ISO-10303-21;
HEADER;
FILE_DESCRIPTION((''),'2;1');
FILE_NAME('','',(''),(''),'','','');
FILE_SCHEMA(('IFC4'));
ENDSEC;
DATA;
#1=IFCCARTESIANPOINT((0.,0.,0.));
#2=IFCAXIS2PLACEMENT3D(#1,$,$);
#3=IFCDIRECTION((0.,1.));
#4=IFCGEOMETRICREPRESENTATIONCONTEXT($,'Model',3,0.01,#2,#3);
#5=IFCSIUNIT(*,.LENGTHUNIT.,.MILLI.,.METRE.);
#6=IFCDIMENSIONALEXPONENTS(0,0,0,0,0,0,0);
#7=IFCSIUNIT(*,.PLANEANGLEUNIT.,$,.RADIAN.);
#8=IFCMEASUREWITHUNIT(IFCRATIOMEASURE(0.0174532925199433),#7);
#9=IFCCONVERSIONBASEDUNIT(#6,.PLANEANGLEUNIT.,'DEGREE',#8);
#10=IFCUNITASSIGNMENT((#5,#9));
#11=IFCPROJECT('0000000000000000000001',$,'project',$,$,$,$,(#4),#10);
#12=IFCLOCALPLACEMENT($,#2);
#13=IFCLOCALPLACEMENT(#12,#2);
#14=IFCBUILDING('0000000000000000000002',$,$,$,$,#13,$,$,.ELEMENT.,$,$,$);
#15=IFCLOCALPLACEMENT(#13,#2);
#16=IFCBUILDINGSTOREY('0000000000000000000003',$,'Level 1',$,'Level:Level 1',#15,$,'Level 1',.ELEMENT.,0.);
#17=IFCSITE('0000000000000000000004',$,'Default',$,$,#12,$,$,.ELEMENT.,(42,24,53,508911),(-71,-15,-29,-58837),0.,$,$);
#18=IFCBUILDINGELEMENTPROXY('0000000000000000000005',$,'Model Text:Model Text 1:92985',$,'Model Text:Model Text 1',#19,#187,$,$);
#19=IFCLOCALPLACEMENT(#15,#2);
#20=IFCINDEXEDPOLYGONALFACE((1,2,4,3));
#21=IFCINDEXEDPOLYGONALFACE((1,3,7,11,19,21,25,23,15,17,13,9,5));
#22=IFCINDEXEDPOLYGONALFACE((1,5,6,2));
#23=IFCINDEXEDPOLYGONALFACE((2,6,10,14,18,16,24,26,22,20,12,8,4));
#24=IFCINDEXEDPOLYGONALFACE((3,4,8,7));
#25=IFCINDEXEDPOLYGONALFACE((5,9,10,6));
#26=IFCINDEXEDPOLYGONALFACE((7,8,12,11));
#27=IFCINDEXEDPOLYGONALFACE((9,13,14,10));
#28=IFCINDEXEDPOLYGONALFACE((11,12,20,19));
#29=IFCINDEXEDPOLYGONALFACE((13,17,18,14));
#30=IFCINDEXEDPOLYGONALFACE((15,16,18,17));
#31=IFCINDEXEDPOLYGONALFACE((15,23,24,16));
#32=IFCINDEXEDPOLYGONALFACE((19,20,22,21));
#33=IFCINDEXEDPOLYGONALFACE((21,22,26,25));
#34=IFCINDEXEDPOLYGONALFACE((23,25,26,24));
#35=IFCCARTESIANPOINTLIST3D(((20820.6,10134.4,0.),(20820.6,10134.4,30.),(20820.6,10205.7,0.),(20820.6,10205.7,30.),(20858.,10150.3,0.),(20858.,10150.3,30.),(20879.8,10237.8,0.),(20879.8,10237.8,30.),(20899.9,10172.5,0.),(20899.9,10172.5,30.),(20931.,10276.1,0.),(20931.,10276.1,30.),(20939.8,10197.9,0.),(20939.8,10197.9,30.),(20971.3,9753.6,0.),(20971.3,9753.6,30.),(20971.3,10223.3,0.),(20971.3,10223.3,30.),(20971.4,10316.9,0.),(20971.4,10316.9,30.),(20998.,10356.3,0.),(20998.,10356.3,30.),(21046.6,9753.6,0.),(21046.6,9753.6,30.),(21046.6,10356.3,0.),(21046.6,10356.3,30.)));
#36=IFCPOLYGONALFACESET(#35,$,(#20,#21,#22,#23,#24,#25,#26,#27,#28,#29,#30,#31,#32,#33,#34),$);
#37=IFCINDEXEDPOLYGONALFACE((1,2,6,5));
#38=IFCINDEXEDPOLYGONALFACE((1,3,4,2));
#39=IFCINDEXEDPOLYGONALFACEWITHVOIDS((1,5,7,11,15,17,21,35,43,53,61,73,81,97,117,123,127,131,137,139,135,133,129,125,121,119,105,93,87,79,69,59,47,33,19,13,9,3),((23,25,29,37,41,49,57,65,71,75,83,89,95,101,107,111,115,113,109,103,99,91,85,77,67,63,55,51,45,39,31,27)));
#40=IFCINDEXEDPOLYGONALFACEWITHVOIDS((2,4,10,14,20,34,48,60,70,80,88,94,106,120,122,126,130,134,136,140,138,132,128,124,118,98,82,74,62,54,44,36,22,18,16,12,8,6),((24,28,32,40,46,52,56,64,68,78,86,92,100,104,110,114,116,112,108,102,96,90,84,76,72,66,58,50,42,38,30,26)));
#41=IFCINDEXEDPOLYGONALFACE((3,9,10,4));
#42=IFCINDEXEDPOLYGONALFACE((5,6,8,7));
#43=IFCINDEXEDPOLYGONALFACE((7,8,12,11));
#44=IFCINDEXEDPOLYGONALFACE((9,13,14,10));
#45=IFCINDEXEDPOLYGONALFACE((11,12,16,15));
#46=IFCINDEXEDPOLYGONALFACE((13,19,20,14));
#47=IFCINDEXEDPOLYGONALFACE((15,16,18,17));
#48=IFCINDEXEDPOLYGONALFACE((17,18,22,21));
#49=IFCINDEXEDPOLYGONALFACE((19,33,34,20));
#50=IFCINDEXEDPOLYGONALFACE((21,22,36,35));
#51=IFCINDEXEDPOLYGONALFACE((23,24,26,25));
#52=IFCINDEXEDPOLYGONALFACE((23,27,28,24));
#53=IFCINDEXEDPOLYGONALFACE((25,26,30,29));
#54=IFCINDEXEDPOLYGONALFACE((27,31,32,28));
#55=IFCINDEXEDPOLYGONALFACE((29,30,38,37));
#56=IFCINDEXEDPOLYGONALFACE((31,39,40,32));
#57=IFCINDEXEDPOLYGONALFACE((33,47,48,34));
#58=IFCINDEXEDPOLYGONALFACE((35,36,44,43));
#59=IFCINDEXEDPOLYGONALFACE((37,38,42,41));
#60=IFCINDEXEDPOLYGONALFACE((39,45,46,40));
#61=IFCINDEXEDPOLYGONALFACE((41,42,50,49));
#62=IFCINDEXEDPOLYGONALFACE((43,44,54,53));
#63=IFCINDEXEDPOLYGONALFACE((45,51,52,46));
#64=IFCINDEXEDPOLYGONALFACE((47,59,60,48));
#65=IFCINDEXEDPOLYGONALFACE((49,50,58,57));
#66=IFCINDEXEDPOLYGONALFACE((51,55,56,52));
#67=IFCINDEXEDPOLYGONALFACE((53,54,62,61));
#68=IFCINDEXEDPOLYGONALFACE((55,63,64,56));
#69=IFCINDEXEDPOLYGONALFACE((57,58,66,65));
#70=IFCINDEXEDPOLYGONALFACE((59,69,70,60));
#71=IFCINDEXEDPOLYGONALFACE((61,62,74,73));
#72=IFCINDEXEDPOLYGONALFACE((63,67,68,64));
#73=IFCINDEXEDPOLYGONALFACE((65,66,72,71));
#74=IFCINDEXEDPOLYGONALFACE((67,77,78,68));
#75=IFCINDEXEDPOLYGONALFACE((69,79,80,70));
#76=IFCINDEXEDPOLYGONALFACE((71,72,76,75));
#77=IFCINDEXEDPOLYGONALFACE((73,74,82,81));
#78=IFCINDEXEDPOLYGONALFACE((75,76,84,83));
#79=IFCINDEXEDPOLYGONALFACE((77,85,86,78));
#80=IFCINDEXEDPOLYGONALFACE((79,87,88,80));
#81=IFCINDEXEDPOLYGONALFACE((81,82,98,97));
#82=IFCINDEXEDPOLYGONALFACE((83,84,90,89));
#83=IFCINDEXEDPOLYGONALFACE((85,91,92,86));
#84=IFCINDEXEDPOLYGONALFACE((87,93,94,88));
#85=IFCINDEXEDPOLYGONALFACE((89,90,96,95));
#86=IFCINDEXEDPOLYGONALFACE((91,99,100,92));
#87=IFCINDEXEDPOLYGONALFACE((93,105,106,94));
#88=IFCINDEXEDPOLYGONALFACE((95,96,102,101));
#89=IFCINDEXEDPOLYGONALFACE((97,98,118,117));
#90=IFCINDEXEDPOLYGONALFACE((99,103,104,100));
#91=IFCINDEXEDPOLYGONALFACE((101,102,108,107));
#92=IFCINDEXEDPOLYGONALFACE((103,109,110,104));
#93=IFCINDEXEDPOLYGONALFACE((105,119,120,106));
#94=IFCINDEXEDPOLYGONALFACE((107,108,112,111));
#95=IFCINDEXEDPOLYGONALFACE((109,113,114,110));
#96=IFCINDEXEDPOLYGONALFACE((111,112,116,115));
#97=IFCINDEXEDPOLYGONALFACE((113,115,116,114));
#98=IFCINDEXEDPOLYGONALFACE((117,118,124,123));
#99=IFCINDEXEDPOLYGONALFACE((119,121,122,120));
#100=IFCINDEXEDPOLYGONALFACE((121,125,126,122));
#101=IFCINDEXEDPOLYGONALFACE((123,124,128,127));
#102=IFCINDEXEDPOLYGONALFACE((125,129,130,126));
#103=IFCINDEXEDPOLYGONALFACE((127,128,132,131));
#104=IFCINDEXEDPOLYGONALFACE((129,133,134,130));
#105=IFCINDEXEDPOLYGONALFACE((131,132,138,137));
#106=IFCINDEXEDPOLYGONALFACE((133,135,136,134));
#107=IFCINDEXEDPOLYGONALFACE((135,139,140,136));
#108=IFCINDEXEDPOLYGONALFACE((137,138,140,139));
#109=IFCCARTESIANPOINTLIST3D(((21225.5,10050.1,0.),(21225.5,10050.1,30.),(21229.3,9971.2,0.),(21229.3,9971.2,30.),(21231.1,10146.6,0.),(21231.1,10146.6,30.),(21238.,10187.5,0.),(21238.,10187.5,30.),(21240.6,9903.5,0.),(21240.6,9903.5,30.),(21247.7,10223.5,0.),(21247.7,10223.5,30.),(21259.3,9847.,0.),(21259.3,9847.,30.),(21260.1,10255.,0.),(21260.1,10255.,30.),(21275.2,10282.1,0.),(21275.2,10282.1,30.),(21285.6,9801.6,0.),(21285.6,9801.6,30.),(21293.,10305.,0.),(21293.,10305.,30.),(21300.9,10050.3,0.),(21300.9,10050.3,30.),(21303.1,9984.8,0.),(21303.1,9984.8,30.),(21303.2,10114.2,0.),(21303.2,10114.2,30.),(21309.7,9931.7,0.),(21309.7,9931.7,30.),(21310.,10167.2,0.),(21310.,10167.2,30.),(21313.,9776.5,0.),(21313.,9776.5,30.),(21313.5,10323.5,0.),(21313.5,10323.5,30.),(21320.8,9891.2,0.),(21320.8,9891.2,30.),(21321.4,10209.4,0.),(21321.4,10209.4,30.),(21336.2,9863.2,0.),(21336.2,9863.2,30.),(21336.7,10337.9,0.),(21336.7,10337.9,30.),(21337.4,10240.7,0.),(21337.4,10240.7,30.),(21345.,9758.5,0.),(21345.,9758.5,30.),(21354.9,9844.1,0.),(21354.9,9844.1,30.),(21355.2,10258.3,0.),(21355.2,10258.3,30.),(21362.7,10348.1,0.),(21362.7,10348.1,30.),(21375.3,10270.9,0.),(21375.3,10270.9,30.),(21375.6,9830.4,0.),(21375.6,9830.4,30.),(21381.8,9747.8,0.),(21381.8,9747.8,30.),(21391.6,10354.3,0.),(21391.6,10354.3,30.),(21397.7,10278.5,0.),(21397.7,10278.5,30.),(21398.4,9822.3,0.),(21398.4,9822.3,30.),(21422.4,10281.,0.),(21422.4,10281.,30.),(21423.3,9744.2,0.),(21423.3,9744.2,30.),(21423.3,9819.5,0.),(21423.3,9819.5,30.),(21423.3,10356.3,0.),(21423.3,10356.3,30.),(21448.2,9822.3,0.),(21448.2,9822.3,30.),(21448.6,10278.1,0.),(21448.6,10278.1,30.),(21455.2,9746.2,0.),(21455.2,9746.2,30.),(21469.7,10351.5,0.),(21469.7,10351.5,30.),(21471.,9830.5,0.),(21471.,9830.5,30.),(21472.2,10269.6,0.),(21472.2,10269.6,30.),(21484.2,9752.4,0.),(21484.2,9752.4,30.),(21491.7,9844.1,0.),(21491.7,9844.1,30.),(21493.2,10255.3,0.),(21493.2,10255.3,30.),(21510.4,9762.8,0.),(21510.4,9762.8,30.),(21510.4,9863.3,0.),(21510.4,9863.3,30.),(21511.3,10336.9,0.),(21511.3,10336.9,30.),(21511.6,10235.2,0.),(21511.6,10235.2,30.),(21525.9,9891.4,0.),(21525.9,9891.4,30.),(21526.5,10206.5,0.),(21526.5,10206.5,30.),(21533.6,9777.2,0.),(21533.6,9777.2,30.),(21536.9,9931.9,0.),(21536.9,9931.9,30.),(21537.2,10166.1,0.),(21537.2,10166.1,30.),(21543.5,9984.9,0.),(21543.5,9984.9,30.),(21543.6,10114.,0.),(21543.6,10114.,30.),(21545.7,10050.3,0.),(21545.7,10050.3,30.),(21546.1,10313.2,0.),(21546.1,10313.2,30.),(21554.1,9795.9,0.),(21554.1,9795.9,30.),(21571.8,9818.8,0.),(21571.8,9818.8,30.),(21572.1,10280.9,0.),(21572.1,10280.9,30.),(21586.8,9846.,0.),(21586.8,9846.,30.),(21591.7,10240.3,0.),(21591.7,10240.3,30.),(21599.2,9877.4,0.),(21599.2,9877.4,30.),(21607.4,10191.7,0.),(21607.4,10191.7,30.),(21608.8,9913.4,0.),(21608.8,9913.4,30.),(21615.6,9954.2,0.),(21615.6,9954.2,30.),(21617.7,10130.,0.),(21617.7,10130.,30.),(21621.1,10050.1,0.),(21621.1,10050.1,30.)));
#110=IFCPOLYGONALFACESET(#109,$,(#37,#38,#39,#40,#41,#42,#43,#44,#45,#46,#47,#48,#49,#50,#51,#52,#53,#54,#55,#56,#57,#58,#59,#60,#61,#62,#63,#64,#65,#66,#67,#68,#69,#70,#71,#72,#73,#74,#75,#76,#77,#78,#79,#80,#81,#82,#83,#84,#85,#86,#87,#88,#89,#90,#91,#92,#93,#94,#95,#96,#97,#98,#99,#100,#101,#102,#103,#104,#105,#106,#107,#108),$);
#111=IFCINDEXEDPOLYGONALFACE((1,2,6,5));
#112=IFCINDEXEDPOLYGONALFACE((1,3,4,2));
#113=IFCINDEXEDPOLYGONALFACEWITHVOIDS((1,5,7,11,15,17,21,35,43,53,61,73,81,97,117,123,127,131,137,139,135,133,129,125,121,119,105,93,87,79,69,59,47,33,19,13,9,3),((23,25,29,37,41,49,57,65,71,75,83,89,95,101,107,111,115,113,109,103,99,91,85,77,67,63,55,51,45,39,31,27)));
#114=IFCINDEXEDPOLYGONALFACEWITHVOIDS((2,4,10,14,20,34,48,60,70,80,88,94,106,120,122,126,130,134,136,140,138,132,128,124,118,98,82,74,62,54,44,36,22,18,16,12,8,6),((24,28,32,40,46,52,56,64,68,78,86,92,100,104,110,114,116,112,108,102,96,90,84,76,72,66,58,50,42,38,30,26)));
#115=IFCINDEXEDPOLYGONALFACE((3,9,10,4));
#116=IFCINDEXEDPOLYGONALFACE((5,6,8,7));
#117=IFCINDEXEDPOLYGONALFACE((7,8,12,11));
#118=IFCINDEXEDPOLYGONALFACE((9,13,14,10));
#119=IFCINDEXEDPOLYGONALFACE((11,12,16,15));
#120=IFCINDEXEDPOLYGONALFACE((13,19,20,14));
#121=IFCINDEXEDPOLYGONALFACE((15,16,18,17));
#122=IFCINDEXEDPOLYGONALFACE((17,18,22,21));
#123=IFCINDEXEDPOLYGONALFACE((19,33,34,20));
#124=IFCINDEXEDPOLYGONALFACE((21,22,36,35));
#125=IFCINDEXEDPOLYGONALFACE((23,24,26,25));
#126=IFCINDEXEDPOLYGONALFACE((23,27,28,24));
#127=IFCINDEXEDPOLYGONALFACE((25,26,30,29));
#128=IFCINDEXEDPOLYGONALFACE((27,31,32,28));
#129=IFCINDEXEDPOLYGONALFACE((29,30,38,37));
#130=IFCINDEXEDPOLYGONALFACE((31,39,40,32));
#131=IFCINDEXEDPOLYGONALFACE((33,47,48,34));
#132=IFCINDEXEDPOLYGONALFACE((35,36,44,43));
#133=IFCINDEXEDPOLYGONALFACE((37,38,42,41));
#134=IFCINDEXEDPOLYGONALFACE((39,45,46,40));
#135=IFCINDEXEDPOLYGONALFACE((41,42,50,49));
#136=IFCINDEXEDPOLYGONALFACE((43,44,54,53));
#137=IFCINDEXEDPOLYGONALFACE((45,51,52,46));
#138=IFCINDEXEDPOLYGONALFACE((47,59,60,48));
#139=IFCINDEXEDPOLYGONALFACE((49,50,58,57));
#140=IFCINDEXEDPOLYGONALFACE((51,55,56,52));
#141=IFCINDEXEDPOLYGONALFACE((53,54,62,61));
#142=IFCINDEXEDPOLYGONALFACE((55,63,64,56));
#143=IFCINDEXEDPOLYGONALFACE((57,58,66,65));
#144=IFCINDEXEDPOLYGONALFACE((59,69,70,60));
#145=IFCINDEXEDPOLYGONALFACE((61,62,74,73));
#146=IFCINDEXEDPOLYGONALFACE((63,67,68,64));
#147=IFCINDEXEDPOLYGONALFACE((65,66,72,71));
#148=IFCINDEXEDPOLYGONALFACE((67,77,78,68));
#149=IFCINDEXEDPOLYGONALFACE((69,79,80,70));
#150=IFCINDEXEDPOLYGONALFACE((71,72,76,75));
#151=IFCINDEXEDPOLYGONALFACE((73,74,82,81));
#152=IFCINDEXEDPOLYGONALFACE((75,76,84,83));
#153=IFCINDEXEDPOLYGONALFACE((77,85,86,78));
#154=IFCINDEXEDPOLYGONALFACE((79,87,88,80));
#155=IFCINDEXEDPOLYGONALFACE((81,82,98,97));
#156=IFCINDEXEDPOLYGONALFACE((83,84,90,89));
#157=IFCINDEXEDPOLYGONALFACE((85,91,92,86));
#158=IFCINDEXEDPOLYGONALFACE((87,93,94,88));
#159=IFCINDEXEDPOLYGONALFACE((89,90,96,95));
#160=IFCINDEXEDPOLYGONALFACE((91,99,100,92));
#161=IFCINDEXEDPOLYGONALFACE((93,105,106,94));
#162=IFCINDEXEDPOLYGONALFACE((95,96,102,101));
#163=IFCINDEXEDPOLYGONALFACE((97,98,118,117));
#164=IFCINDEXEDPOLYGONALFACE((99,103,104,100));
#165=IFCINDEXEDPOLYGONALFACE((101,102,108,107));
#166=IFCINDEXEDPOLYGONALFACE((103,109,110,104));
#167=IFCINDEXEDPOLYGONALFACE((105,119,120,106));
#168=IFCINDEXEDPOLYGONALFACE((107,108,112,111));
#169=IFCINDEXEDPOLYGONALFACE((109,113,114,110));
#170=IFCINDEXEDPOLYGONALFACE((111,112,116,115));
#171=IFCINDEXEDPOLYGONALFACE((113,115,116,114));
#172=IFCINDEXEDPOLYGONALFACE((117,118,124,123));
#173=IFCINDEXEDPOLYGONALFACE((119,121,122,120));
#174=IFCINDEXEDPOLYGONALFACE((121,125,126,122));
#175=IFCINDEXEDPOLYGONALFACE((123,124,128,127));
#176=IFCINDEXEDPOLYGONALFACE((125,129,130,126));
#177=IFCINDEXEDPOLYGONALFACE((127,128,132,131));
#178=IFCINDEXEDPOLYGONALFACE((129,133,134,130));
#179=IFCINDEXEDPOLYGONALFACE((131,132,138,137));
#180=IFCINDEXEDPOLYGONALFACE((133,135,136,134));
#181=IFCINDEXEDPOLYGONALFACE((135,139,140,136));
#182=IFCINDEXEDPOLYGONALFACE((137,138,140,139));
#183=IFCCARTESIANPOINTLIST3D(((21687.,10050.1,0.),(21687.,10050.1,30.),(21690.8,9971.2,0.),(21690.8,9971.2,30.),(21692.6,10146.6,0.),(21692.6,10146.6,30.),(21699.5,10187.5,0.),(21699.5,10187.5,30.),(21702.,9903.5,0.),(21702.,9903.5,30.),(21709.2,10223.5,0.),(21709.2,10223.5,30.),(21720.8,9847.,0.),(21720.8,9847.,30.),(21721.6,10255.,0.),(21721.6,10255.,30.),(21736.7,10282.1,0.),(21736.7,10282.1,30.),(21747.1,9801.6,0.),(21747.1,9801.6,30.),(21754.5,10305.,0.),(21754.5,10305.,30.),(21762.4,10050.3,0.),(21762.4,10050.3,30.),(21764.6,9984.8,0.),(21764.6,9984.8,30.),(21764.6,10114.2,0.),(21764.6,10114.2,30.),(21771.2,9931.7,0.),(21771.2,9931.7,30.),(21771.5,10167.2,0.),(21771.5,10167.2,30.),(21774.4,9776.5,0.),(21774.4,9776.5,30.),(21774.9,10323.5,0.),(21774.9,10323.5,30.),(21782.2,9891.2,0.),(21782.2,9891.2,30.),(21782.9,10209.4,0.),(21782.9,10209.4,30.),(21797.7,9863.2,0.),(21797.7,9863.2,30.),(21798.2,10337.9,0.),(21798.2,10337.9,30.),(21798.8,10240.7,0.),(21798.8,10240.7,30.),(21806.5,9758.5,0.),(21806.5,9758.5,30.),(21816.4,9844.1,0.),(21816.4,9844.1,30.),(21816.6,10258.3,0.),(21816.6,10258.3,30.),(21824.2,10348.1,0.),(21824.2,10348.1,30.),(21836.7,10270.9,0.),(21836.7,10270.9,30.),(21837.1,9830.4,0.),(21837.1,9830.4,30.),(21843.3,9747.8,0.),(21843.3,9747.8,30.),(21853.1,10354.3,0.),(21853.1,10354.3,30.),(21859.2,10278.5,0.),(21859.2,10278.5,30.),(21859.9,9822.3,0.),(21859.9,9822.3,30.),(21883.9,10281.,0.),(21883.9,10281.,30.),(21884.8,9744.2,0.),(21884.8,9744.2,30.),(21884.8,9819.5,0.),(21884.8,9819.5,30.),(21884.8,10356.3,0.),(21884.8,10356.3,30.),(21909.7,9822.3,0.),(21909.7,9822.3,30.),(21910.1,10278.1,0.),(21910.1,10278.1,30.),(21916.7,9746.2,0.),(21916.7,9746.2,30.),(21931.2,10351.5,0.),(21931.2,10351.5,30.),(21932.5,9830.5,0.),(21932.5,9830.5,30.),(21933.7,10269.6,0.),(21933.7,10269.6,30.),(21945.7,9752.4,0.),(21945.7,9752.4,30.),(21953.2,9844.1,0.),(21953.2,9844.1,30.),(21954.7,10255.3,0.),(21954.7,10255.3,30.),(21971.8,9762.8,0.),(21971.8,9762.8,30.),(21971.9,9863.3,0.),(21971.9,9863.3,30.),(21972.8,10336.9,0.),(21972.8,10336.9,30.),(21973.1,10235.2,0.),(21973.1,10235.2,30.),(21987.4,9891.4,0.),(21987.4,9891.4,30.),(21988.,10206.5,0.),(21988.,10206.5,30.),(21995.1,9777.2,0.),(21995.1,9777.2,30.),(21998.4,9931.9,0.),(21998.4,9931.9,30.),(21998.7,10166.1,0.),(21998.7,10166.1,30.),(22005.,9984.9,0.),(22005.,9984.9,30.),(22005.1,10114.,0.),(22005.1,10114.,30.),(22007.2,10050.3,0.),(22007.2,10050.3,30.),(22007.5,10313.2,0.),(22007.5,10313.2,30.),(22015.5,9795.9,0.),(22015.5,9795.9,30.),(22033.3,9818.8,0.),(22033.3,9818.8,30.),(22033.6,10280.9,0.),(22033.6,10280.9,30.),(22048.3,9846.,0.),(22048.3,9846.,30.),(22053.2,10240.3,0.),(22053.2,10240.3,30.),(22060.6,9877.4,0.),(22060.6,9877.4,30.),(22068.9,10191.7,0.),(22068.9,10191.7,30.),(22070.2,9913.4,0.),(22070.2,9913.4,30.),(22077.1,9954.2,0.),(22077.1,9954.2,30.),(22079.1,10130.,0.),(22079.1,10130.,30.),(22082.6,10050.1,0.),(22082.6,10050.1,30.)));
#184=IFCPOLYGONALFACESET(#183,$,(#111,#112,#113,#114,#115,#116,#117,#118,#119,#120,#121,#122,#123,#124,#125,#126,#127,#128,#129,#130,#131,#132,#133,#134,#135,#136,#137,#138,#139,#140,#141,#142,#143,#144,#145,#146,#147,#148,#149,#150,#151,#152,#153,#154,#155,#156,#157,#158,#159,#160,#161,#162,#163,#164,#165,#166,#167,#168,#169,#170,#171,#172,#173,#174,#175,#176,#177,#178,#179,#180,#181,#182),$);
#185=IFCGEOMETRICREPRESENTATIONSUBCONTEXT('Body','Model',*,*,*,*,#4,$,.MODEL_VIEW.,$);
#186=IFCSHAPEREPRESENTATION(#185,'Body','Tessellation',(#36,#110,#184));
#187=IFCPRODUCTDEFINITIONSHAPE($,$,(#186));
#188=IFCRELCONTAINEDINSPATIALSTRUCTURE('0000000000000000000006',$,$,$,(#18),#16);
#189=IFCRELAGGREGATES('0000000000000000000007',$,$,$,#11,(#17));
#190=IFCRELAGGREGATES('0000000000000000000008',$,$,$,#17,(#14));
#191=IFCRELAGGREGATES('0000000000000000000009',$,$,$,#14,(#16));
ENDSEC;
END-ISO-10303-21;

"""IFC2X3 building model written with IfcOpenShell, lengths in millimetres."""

from ifc_helpers import new_model, entity, si_unit, converted_unit, direction, frame, origin, place, context, subcontext, project, spatial, polyline, outline, extrude, element, save


model = new_model("IFC2X3")

# Units and contexts
model_context = context("Model", 3, precision=0.01, world=origin(), true_north=direction((0.0, 1.0)))
body_context = subcontext(model_context, "Body", "Model", "MODEL_VIEW")
ifc_project = project(units=[si_unit("LENGTHUNIT", "METRE", prefix="MILLI"), converted_unit("PLANEANGLEUNIT", "DEGREE", entity("IfcRatioMeasure", 0.0174532925199433), si_unit("PLANEANGLEUNIT", "RADIAN"), dimensions=[0, 0, 0, 0, 0, 0, 0])], contexts=[model_context])

# Site, building, storey
site_placement = place(None, origin())
site = spatial("IfcSite", under=ifc_project, at=site_placement, Name="Default", CompositionType="ELEMENT", RefLatitude=(42, 24, 53, 508911), RefLongitude=(-71, -15, -29, -58837), RefElevation=0.0)
building_placement = place(site_placement, origin())
building = spatial("IfcBuilding", under=site, at=building_placement, CompositionType="ELEMENT")
storey_placement = place(building_placement, origin())
storey = spatial("IfcBuildingStorey", under=building, at=storey_placement, Name="Level 1", ObjectType="Level:Level 1", LongName="Level 1", CompositionType="ELEMENT", Elevation=0.0)

# Building element proxy
proxy_1_placement = place(storey_placement, origin())
element("IfcBuildingElementProxy", 1, at=proxy_1_placement, inside=storey, Name="Model Text:Model Text 1:92985", ObjectType="Model Text:Model Text 1", context=body_context, shape_type="SweptSolid", body=[
    extrude(outline(polyline([(-410.6, -111.6), (192.1, -111.6), (192.1, -63.1), (152.7, -36.4), (111.9, 4.0), (73.6, 55.2), (41.4, 114.4), (-29.8, 114.4), (-13.9, 77.0), (8.3, 35.1), (33.7, -4.8), (59.1, -36.3), (-410.6, -36.3), (-410.6, -111.6)])), frame((20935.0, 10164.2, 0.0), z_axis=(0.0, 0.0, 1.0), x_axis=(0.0, 1.0, 0.0)), (0.0, 0.0, 1.0), 30.0),
    extrude(outline(polyline([(-10.6, -198.7), (68.3, -198.7), (136.5, -190.7), (193.9, -174.7), (240.5, -150.6), (266.9, -124.4), (286.3, -93.2), (298.8, -57.0), (304.3, -15.7), (303.8, 16.2), (299.0, 45.5), (289.9, 72.1), (276.6, 96.0), (258.9, 117.3), (236.9, 136.2), (210.4, 152.5), (179.6, 166.3), (144.1, 177.6), (103.7, 186.3), (8.2, 196.4), (-71.8, 196.7), (-134.0, 189.4), (-183.3, 176.1), (-224.7, 158.4), (-258.2, 133.9), (-283.5, 100.3), (-300.1, 59.5), (-307.1, 13.4), (-306.6, -18.4), (-301.8, -47.5), (-292.8, -74.0), (-279.6, -97.9), (-262.0, -119.2), (-240.0, -138.1), (-213.6, -154.5), (-182.8, -168.4), (-147.3, -179.8), (-106.7, -188.6), (-10.6, -198.7)]), holes=[polyline([(-7.2, -123.5), (-71.0, -118.2), (-123.6, -108.8), (-165.2, -95.4), (-195.7, -78.0), (-212.4, -59.4), (-224.1, -38.7), (-230.6, -15.9), (-231.9, 8.9), (-227.8, 35.0), (-218.1, 58.1), (-202.8, 78.4), (-182.0, 95.8), (-152.6, 109.4), (-111.7, 118.1), (-59.4, 122.0), (4.4, 121.1), (69.6, 115.8), (122.2, 106.7), (162.2, 93.7), (189.5, 77.0), (207.7, 57.4), (220.4, 36.0), (227.5, 12.8), (229.1, -12.1), (225.2, -36.8), (215.9, -59.2), (201.3, -79.3), (181.4, -97.1), (152.6, -111.2), (111.6, -120.3), (58.3, -124.4), (-7.2, -123.5)])]), frame((21424.6, 10048.9, 0.0), z_axis=(0.0, 0.0, 1.0), x_axis=(0.047515, -0.998871, 0.0)), (0.0, 0.0, 1.0), 30.0),
    extrude(outline(polyline([(-10.6, -198.7), (68.3, -198.7), (136.5, -190.7), (193.9, -174.7), (240.5, -150.6), (266.9, -124.4), (286.3, -93.2), (298.8, -57.0), (304.3, -15.7), (303.8, 16.2), (299.0, 45.5), (289.9, 72.1), (276.6, 96.0), (258.9, 117.3), (236.9, 136.2), (210.4, 152.5), (179.6, 166.3), (144.1, 177.6), (103.7, 186.3), (8.2, 196.4), (-71.8, 196.7), (-134.0, 189.4), (-183.3, 176.1), (-224.7, 158.4), (-258.2, 133.9), (-283.5, 100.3), (-300.1, 59.5), (-307.1, 13.4), (-306.6, -18.4), (-301.8, -47.5), (-292.8, -74.0), (-279.6, -97.9), (-262.0, -119.2), (-240.0, -138.1), (-213.6, -154.5), (-182.8, -168.4), (-147.3, -179.8), (-106.7, -188.6), (-10.6, -198.7)]), holes=[polyline([(-7.2, -123.5), (-71.0, -118.2), (-123.6, -108.8), (-165.2, -95.4), (-195.7, -78.0), (-212.4, -59.4), (-224.1, -38.7), (-230.6, -15.9), (-231.9, 8.9), (-227.8, 35.0), (-218.1, 58.1), (-202.8, 78.4), (-182.0, 95.8), (-152.6, 109.4), (-111.7, 118.1), (-59.4, 122.0), (4.4, 121.1), (69.6, 115.8), (122.2, 106.7), (162.2, 93.7), (189.5, 77.0), (207.7, 57.4), (220.4, 36.0), (227.5, 12.8), (229.1, -12.1), (225.2, -36.8), (215.9, -59.2), (201.3, -79.3), (181.4, -97.1), (152.6, -111.2), (111.6, -120.3), (58.3, -124.4), (-7.2, -123.5)])]), frame((21886.0, 10048.9, 0.0), z_axis=(0.0, 0.0, 1.0), x_axis=(0.047515, -0.998871, 0.0)), (0.0, 0.0, 1.0), 30.0),
])

save(model, "model.ifc")
